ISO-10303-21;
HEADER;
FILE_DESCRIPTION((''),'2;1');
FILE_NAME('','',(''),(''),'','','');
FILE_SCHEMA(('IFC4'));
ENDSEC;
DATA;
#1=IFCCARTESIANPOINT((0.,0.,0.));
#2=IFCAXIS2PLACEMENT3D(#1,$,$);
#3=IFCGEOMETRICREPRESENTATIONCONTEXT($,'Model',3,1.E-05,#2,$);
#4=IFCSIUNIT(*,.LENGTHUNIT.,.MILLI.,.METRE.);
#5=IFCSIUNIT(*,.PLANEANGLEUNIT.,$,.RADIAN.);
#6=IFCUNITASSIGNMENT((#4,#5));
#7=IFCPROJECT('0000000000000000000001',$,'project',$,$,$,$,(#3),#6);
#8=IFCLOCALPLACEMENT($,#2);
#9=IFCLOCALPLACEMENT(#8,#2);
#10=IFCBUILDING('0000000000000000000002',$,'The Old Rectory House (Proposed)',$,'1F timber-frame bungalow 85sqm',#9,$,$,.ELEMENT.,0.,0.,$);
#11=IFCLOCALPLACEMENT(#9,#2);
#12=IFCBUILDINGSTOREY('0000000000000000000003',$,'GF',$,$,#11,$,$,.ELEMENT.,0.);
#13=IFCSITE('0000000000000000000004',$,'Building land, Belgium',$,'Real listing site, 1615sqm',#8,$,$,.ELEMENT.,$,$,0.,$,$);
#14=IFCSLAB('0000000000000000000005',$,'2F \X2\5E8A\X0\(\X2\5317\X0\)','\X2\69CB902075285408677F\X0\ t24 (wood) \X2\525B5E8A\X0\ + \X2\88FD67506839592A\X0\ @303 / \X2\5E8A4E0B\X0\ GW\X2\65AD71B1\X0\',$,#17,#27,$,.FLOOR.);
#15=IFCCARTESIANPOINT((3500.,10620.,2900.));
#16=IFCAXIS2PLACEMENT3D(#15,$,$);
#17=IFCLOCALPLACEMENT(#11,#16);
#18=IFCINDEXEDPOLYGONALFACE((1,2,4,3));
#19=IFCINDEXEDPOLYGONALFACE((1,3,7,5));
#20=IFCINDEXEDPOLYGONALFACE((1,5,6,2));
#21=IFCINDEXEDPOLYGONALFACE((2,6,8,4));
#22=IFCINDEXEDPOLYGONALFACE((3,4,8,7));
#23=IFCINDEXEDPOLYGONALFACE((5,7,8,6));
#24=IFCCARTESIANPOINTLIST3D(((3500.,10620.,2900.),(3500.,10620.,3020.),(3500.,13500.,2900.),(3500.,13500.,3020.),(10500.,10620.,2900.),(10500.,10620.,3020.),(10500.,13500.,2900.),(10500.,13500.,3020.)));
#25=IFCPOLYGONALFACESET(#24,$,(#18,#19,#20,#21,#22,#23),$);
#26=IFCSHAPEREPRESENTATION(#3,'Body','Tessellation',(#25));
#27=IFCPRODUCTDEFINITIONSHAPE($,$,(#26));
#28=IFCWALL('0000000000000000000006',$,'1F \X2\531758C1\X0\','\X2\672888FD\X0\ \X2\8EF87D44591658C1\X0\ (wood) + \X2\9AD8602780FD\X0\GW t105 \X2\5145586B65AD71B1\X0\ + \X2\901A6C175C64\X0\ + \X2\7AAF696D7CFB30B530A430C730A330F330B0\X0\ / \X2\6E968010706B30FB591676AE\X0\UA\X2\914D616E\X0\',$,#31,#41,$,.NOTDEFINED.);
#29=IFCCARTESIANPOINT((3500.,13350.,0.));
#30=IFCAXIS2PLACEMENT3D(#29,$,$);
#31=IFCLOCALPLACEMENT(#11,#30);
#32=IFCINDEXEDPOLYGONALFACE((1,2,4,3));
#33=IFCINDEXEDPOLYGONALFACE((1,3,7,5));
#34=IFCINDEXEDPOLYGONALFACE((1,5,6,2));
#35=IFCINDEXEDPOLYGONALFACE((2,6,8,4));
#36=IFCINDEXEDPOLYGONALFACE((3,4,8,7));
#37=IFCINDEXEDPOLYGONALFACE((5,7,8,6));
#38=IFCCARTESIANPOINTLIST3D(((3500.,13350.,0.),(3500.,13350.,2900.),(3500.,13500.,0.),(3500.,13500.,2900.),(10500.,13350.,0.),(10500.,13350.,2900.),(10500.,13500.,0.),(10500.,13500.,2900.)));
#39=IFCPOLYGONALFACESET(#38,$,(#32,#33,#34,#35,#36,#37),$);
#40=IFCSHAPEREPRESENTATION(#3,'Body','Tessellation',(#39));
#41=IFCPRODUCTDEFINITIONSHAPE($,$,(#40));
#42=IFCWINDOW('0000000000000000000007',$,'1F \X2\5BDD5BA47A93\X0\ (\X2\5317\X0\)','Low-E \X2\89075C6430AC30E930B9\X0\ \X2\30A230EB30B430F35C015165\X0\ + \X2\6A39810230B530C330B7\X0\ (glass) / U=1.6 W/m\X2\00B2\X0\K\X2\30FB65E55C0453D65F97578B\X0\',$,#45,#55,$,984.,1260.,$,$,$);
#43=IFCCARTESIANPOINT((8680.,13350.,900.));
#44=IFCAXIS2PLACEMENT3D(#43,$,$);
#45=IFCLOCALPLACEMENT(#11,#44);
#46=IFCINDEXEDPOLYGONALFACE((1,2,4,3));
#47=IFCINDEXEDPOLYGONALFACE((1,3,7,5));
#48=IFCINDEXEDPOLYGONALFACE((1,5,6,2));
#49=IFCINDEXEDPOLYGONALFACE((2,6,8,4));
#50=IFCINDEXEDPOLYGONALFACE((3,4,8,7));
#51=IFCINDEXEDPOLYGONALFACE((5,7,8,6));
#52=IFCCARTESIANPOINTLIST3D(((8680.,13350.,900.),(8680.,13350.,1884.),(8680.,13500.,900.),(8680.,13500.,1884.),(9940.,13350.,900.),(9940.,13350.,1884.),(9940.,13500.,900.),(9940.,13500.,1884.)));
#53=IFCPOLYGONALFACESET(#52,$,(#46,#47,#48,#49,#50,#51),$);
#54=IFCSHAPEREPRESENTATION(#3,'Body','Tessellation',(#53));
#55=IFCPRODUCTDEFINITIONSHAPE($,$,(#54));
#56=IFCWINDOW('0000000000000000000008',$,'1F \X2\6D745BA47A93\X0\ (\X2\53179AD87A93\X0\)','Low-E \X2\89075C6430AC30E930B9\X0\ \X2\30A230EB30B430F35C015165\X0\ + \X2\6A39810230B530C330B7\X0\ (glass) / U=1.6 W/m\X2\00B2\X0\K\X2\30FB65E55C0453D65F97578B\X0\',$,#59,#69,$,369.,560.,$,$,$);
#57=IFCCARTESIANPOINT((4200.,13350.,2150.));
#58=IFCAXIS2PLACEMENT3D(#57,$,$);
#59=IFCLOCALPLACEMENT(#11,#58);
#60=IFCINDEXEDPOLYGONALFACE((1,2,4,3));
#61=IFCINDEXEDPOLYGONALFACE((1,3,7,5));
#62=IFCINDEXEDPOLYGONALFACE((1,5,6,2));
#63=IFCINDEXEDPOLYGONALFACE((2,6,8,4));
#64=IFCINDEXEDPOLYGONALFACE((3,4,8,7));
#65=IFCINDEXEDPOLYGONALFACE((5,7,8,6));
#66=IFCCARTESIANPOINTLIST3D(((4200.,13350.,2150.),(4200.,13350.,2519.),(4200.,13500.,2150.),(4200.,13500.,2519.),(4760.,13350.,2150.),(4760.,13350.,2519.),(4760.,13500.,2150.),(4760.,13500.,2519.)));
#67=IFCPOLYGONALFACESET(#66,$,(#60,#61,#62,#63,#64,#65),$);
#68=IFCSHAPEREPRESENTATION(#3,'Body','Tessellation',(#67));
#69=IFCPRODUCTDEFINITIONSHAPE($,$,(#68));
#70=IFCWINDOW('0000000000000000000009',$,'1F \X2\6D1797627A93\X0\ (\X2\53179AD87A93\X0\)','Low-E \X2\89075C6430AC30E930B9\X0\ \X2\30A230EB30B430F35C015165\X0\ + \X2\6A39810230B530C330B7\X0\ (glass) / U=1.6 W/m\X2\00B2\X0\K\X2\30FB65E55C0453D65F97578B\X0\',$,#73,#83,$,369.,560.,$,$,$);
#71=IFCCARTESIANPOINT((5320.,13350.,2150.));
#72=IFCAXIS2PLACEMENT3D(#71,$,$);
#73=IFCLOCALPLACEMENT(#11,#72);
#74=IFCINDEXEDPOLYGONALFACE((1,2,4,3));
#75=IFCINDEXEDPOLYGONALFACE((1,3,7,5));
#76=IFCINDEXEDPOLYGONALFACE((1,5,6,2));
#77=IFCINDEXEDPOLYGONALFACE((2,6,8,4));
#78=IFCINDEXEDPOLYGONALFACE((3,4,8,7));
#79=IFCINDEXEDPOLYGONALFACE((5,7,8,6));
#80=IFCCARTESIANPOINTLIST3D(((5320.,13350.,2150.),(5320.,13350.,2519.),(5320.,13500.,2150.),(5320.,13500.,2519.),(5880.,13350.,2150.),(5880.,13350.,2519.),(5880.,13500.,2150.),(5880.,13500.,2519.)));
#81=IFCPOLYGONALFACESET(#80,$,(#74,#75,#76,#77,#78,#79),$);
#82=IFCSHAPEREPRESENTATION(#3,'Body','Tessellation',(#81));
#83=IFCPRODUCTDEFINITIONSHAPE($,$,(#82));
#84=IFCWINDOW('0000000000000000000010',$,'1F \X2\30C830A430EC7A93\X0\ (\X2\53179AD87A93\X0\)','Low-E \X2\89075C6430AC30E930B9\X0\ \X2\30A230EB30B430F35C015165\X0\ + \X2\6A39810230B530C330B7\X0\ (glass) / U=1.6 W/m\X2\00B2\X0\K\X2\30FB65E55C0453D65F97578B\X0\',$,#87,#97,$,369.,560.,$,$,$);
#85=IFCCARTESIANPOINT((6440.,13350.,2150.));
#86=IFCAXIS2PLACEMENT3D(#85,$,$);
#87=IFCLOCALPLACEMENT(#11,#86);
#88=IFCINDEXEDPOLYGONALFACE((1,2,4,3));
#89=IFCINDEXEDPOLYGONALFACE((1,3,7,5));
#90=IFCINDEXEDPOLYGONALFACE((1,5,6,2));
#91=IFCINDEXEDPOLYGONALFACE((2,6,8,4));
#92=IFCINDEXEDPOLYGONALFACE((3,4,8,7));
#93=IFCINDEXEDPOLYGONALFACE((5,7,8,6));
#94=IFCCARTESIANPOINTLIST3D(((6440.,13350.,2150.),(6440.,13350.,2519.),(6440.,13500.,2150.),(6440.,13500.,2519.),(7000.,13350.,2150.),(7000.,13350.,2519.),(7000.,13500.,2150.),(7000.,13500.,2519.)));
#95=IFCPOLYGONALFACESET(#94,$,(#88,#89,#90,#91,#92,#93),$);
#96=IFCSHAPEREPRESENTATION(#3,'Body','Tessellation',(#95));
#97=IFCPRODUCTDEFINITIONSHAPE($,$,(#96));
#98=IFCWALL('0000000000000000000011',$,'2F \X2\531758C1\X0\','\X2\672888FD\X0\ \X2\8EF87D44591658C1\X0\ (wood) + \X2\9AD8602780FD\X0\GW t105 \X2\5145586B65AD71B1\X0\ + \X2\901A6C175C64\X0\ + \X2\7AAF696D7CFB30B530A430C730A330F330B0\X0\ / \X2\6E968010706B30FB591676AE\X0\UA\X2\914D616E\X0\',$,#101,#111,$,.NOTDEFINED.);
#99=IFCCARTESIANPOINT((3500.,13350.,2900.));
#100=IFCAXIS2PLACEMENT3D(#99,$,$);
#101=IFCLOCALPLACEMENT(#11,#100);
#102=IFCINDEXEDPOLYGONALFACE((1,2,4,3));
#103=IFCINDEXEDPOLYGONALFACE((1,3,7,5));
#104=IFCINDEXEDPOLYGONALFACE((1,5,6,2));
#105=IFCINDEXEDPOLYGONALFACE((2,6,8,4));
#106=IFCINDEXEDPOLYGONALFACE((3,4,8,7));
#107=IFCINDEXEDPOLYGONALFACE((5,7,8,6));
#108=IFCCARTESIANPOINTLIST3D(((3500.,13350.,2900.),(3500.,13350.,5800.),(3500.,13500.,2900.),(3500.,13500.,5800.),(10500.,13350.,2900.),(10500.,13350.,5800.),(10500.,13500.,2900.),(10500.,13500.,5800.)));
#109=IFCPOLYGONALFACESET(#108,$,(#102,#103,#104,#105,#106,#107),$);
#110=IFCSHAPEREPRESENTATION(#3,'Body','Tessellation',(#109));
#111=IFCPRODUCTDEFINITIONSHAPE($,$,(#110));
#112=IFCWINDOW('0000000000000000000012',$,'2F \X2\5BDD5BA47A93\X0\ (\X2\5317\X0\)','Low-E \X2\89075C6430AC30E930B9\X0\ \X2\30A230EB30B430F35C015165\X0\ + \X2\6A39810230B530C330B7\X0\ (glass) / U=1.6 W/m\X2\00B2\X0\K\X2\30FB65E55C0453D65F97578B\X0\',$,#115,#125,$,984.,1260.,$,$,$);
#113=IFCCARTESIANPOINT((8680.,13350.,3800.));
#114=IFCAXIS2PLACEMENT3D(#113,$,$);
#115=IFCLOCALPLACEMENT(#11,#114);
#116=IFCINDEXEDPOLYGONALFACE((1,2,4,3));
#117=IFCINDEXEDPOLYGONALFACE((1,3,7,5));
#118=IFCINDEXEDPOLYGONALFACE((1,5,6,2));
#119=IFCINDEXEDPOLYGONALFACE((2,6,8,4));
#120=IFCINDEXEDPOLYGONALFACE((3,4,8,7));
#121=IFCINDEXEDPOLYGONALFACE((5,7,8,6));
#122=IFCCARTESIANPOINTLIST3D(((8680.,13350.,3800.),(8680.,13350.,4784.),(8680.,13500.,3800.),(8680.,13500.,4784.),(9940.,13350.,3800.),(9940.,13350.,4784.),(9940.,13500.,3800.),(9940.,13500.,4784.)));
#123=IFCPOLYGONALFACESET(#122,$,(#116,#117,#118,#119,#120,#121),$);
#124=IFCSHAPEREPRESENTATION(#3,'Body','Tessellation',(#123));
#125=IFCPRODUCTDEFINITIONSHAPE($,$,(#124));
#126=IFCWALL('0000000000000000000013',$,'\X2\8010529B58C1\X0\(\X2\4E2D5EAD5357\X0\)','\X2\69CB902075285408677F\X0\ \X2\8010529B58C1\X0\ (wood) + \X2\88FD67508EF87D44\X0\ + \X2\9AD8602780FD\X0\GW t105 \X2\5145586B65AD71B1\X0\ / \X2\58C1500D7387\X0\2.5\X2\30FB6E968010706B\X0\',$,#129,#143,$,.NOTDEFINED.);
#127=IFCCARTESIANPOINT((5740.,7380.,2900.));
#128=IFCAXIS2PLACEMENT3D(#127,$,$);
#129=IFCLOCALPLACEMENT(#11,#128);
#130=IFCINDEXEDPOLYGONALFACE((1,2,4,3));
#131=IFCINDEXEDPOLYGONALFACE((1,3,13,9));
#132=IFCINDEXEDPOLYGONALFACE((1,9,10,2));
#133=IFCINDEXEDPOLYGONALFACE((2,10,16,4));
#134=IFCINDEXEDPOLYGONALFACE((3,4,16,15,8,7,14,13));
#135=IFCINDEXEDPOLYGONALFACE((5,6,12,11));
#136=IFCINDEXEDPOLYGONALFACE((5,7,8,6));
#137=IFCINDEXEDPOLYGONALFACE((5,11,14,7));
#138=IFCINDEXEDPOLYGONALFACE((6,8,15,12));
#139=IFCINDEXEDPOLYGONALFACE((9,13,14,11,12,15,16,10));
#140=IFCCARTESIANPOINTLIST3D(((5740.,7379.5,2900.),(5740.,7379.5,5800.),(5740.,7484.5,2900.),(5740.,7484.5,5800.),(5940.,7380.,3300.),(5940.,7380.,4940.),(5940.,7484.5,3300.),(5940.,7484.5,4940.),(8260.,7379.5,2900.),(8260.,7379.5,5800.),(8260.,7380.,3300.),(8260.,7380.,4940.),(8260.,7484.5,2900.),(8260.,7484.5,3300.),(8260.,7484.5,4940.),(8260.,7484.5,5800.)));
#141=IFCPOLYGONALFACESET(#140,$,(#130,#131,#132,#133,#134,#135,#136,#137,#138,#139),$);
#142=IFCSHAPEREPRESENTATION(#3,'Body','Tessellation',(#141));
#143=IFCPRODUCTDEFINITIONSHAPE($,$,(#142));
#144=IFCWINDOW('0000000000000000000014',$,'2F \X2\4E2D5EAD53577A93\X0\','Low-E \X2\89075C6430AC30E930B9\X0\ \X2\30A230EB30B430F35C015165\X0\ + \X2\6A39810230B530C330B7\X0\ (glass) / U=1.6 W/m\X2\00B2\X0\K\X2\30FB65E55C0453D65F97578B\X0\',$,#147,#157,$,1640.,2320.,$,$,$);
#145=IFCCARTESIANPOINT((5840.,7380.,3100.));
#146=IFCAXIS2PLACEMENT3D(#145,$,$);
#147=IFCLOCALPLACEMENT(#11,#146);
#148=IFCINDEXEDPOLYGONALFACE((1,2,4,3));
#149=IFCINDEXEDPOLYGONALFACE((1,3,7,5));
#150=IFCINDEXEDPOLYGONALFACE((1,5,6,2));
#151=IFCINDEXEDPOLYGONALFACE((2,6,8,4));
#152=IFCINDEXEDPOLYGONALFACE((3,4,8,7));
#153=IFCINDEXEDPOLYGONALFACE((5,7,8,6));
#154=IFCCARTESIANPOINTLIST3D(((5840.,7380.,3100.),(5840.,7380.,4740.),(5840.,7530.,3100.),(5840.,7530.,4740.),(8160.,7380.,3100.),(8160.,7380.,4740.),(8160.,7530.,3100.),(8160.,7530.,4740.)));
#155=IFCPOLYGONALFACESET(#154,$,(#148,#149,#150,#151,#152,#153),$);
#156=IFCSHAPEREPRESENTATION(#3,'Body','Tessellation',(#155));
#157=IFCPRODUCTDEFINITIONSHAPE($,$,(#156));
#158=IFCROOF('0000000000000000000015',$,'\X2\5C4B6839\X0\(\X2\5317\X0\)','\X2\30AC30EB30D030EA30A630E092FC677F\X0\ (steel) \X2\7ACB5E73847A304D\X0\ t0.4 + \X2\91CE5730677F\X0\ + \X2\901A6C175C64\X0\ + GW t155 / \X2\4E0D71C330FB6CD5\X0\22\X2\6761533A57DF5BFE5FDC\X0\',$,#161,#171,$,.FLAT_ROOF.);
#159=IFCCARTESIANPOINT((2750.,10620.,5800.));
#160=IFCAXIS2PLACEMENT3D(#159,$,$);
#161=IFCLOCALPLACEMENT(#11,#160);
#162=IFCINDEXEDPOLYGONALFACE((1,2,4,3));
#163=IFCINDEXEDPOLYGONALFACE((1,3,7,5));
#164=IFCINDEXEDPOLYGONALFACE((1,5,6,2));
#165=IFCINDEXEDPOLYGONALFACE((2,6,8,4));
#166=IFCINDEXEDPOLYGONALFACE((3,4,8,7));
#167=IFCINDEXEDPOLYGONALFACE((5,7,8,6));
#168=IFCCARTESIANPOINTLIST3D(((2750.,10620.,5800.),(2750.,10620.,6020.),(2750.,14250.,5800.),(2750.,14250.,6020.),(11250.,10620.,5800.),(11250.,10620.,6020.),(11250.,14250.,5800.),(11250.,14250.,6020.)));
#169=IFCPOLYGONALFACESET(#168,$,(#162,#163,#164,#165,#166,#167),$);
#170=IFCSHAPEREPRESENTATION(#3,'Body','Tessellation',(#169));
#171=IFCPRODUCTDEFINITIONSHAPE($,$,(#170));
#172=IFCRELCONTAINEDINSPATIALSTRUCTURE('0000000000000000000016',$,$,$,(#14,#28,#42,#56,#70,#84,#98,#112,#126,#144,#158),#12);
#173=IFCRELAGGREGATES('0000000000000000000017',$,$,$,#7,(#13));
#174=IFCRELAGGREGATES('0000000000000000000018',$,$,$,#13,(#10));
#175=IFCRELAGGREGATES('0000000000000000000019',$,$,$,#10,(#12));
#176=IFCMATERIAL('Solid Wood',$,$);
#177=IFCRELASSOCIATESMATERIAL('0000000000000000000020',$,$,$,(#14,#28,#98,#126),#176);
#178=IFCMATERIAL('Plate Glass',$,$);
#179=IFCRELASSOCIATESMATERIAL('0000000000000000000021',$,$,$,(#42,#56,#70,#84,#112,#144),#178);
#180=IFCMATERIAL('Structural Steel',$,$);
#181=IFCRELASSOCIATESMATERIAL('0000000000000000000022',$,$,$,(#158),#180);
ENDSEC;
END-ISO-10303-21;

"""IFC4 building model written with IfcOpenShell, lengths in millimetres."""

from ifc_helpers import new_model, si_unit, frame, frame_2d, origin, place, context, project, spatial, rectangle, extrude, material, element, fill, save


model = new_model("IFC4")

# Units and contexts
model_context = context("Model", 3, precision=1e-05, world=origin())
ifc_project = project(units=[si_unit("LENGTHUNIT", "METRE", prefix="MILLI"), si_unit("PLANEANGLEUNIT", "RADIAN")], contexts=[model_context])

# Site, building, storey
site_placement = place(None, origin())
site = spatial("IfcSite", under=ifc_project, at=site_placement, Name="Building land, Belgium", ObjectType="Real listing site, 1615sqm", CompositionType="ELEMENT", RefElevation=0.0)
building_placement = place(site_placement, origin())
building = spatial("IfcBuilding", under=site, at=building_placement, Name="The Old Rectory House (Proposed)", ObjectType="1F timber-frame bungalow 85sqm", CompositionType="ELEMENT", ElevationOfRefHeight=0.0, ElevationOfTerrain=0.0)
storey_placement = place(building_placement, origin())
storey = spatial("IfcBuildingStorey", under=building, at=storey_placement, Name="GF", CompositionType="ELEMENT", Elevation=0.0)

# Slab
ifc_material_1 = material(Name="Solid Wood")
slab_1_placement = place(storey_placement, frame((3500.0, 10620.0, 2900.0)))
element("IfcSlab", 1, at=slab_1_placement, inside=storey, material=ifc_material_1, Name="2F 床(北)", Description="構造用合板 t24 (wood) 剛床 + 製材根太 @303 / 床下 GW断熱", PredefinedType="FLOOR", context=model_context, shape_type="SweptSolid", body=[
    extrude(rectangle(XDim=7000.0, YDim=2880.0, at=frame_2d((3500.0, 1440.0))), frame((3500.0, 10620.0, 2900.0)), (0.0, 0.0, 1.0), 120.0),
])

# Wall, openings, windows
wall_1_placement = place(storey_placement, frame((3500.0, 13350.0, 0.0)))
wall_1 = element("IfcWall", 2, at=wall_1_placement, inside=storey, material=ifc_material_1, Name="1F 北壁", Description="木製 軸組外壁 (wood) + 高性能GW t105 充填断熱 + 通気層 + 窯業系サイディング / 準耐火・外皮UA配慮", PredefinedType="NOTDEFINED", context=model_context, shape_type="SweptSolid", body=[
    extrude(rectangle(XDim=7000.0, YDim=150.0, at=frame_2d((3500.0, 75.0))), frame((3500.0, 13350.0, 0.0)), (0.0, 0.0, 1.0), 2900.0),
])
opening_1_placement = place(storey_placement, frame((8680.0, 13350.0, 900.0)))
opening_1 = element("IfcOpeningElement", 3, at=opening_1_placement, cuts=wall_1, PredefinedType="NOTDEFINED", context=model_context, shape_type="SweptSolid", body=[
    extrude(rectangle(XDim=1260.0, YDim=150.0, at=frame_2d((630.0, 75.0))), frame((8680.0, 13350.0, 900.0)), (0.0, 0.0, 1.0), 984.0),
])
opening_2_placement = place(storey_placement, frame((4200.0, 13350.0, 2150.0)))
opening_2 = element("IfcOpeningElement", 4, at=opening_2_placement, cuts=wall_1, PredefinedType="NOTDEFINED", context=model_context, shape_type="SweptSolid", body=[
    extrude(rectangle(XDim=560.0, YDim=150.0, at=frame_2d((280.0, 75.0))), frame((4200.0, 13350.0, 2150.0)), (0.0, 0.0, 1.0), 369.0),
])
opening_3_placement = place(storey_placement, frame((5320.0, 13350.0, 2150.0)))
opening_3 = element("IfcOpeningElement", 5, at=opening_3_placement, cuts=wall_1, PredefinedType="NOTDEFINED", context=model_context, shape_type="SweptSolid", body=[
    extrude(rectangle(XDim=560.0, YDim=150.0, at=frame_2d((280.0, 75.0))), frame((5320.0, 13350.0, 2150.0)), (0.0, 0.0, 1.0), 369.0),
])
opening_4_placement = place(storey_placement, frame((6440.0, 13350.0, 2150.0)))
opening_4 = element("IfcOpeningElement", 6, at=opening_4_placement, cuts=wall_1, PredefinedType="NOTDEFINED", context=model_context, shape_type="SweptSolid", body=[
    extrude(rectangle(XDim=560.0, YDim=150.0, at=frame_2d((280.0, 75.0))), frame((6440.0, 13350.0, 2150.0)), (0.0, 0.0, 1.0), 369.0),
])
ifc_material_2 = material(Name="Plate Glass")
window_1_placement = place(storey_placement, frame((8680.0, 13350.0, 900.0)))
window_1 = element("IfcWindow", 7, at=window_1_placement, inside=storey, material=ifc_material_2, Name="1F 寝室窓 (北)", Description="Low-E 複層ガラス アルゴン封入 + 樹脂サッシ (glass) / U=1.6 W/m²K・日射取得型", OverallHeight=984.0, OverallWidth=1260.0, context=model_context, shape_type="SweptSolid", body=[
    extrude(rectangle(XDim=1260.0, YDim=150.0, at=frame_2d((630.0, 75.0))), frame((8680.0, 13350.0, 900.0)), (0.0, 0.0, 1.0), 984.0),
])
fill(opening_1, window_1)
window_2_placement = place(storey_placement, frame((4200.0, 13350.0, 2150.0)))
window_2 = element("IfcWindow", 8, at=window_2_placement, inside=storey, material=ifc_material_2, Name="1F 浴室窓 (北高窓)", Description="Low-E 複層ガラス アルゴン封入 + 樹脂サッシ (glass) / U=1.6 W/m²K・日射取得型", OverallHeight=369.0, OverallWidth=560.0, context=model_context, shape_type="SweptSolid", body=[
    extrude(rectangle(XDim=560.0, YDim=150.0, at=frame_2d((280.0, 75.0))), frame((4200.0, 13350.0, 2150.0)), (0.0, 0.0, 1.0), 369.0),
])
fill(opening_2, window_2)
window_3_placement = place(storey_placement, frame((5320.0, 13350.0, 2150.0)))
window_3 = element("IfcWindow", 9, at=window_3_placement, inside=storey, material=ifc_material_2, Name="1F 洗面窓 (北高窓)", Description="Low-E 複層ガラス アルゴン封入 + 樹脂サッシ (glass) / U=1.6 W/m²K・日射取得型", OverallHeight=369.0, OverallWidth=560.0, context=model_context, shape_type="SweptSolid", body=[
    extrude(rectangle(XDim=560.0, YDim=150.0, at=frame_2d((280.0, 75.0))), frame((5320.0, 13350.0, 2150.0)), (0.0, 0.0, 1.0), 369.0),
])
fill(opening_3, window_3)
window_4_placement = place(storey_placement, frame((6440.0, 13350.0, 2150.0)))
window_4 = element("IfcWindow", 10, at=window_4_placement, inside=storey, material=ifc_material_2, Name="1F トイレ窓 (北高窓)", Description="Low-E 複層ガラス アルゴン封入 + 樹脂サッシ (glass) / U=1.6 W/m²K・日射取得型", OverallHeight=369.0, OverallWidth=560.0, context=model_context, shape_type="SweptSolid", body=[
    extrude(rectangle(XDim=560.0, YDim=150.0, at=frame_2d((280.0, 75.0))), frame((6440.0, 13350.0, 2150.0)), (0.0, 0.0, 1.0), 369.0),
])
fill(opening_4, window_4)

# Walls, openings, windows
wall_2_placement = place(storey_placement, frame((3500.0, 13350.0, 2900.0)))
wall_2 = element("IfcWall", 11, at=wall_2_placement, inside=storey, material=ifc_material_1, Name="2F 北壁", Description="木製 軸組外壁 (wood) + 高性能GW t105 充填断熱 + 通気層 + 窯業系サイディング / 準耐火・外皮UA配慮", PredefinedType="NOTDEFINED", context=model_context, shape_type="SweptSolid", body=[
    extrude(rectangle(XDim=7000.0, YDim=150.0, at=frame_2d((3500.0, 75.0))), frame((3500.0, 13350.0, 2900.0)), (0.0, 0.0, 1.0), 2900.0),
])
opening_5_placement = place(storey_placement, frame((8680.0, 13350.0, 3800.0)))
opening_5 = element("IfcOpeningElement", 12, at=opening_5_placement, cuts=wall_2, PredefinedType="NOTDEFINED", context=model_context, shape_type="SweptSolid", body=[
    extrude(rectangle(XDim=1260.0, YDim=150.0, at=frame_2d((630.0, 75.0))), frame((8680.0, 13350.0, 3800.0)), (0.0, 0.0, 1.0), 984.0),
])
window_5_placement = place(storey_placement, frame((8680.0, 13350.0, 3800.0)))
window_5 = element("IfcWindow", 13, at=window_5_placement, inside=storey, material=ifc_material_2, Name="2F 寝室窓 (北)", Description="Low-E 複層ガラス アルゴン封入 + 樹脂サッシ (glass) / U=1.6 W/m²K・日射取得型", OverallHeight=984.0, OverallWidth=1260.0, context=model_context, shape_type="SweptSolid", body=[
    extrude(rectangle(XDim=1260.0, YDim=150.0, at=frame_2d((630.0, 75.0))), frame((8680.0, 13350.0, 3800.0)), (0.0, 0.0, 1.0), 984.0),
])
fill(opening_5, window_5)
wall_3_placement = place(storey_placement, frame((5740.0, 7380.0, 2900.0)))
wall_3 = element("IfcWall", 14, at=wall_3_placement, inside=storey, material=ifc_material_1, Name="耐力壁(中庭南)", Description="構造用合板 耐力壁 (wood) + 製材軸組 + 高性能GW t105 充填断熱 / 壁倍率2.5・準耐火", PredefinedType="NOTDEFINED", context=model_context, shape_type="SweptSolid", body=[
    extrude(rectangle(XDim=2520.0, YDim=105.0, at=frame_2d((1260.0, 52.0))), frame((5740.0, 7380.0, 2900.0)), (0.0, 0.0, 1.0), 2900.0),
])
opening_6_placement = place(storey_placement, frame((5840.0, 7380.0, 3100.0)))
opening_6 = element("IfcOpeningElement", 15, at=opening_6_placement, cuts=wall_3, PredefinedType="NOTDEFINED", context=model_context, shape_type="SweptSolid", body=[
    extrude(rectangle(XDim=2320.0, YDim=150.0, at=frame_2d((1160.0, 75.0))), frame((5840.0, 7380.0, 3100.0)), (0.0, 0.0, 1.0), 1640.0),
])
window_6_placement = place(storey_placement, frame((5840.0, 7380.0, 3100.0)))
window_6 = element("IfcWindow", 16, at=window_6_placement, inside=storey, material=ifc_material_2, Name="2F 中庭南窓", Description="Low-E 複層ガラス アルゴン封入 + 樹脂サッシ (glass) / U=1.6 W/m²K・日射取得型", OverallHeight=1640.0, OverallWidth=2320.0, context=model_context, shape_type="SweptSolid", body=[
    extrude(rectangle(XDim=2320.0, YDim=150.0, at=frame_2d((1160.0, 75.0))), frame((5840.0, 7380.0, 3100.0)), (0.0, 0.0, 1.0), 1640.0),
])
fill(opening_6, window_6)

# Roof
ifc_material_3 = material(Name="Structural Steel")
for number, where, name in (
    (17, (2750.0, 10620.0, 5800.0), "屋根(北)"),
):
    element("IfcRoof", number, at=place(storey_placement, frame(where)), inside=storey, material=ifc_material_3, Name=name, Description="ガルバリウム鋼板 (steel) 立平葺き t0.4 + 野地板 + 通気層 + GW t155 / 不燃・法22条区域対応", PredefinedType="FLAT_ROOF", context=model_context, shape_type="SweptSolid", body=[
        extrude(rectangle(XDim=8500.0, YDim=3630.0, at=frame_2d((4250.0, 1815.0))), frame((2750.0, 10620.0, 5800.0)), (0.0, 0.0, 1.0), 220.0),
    ])

save(model, "model.ifc")
